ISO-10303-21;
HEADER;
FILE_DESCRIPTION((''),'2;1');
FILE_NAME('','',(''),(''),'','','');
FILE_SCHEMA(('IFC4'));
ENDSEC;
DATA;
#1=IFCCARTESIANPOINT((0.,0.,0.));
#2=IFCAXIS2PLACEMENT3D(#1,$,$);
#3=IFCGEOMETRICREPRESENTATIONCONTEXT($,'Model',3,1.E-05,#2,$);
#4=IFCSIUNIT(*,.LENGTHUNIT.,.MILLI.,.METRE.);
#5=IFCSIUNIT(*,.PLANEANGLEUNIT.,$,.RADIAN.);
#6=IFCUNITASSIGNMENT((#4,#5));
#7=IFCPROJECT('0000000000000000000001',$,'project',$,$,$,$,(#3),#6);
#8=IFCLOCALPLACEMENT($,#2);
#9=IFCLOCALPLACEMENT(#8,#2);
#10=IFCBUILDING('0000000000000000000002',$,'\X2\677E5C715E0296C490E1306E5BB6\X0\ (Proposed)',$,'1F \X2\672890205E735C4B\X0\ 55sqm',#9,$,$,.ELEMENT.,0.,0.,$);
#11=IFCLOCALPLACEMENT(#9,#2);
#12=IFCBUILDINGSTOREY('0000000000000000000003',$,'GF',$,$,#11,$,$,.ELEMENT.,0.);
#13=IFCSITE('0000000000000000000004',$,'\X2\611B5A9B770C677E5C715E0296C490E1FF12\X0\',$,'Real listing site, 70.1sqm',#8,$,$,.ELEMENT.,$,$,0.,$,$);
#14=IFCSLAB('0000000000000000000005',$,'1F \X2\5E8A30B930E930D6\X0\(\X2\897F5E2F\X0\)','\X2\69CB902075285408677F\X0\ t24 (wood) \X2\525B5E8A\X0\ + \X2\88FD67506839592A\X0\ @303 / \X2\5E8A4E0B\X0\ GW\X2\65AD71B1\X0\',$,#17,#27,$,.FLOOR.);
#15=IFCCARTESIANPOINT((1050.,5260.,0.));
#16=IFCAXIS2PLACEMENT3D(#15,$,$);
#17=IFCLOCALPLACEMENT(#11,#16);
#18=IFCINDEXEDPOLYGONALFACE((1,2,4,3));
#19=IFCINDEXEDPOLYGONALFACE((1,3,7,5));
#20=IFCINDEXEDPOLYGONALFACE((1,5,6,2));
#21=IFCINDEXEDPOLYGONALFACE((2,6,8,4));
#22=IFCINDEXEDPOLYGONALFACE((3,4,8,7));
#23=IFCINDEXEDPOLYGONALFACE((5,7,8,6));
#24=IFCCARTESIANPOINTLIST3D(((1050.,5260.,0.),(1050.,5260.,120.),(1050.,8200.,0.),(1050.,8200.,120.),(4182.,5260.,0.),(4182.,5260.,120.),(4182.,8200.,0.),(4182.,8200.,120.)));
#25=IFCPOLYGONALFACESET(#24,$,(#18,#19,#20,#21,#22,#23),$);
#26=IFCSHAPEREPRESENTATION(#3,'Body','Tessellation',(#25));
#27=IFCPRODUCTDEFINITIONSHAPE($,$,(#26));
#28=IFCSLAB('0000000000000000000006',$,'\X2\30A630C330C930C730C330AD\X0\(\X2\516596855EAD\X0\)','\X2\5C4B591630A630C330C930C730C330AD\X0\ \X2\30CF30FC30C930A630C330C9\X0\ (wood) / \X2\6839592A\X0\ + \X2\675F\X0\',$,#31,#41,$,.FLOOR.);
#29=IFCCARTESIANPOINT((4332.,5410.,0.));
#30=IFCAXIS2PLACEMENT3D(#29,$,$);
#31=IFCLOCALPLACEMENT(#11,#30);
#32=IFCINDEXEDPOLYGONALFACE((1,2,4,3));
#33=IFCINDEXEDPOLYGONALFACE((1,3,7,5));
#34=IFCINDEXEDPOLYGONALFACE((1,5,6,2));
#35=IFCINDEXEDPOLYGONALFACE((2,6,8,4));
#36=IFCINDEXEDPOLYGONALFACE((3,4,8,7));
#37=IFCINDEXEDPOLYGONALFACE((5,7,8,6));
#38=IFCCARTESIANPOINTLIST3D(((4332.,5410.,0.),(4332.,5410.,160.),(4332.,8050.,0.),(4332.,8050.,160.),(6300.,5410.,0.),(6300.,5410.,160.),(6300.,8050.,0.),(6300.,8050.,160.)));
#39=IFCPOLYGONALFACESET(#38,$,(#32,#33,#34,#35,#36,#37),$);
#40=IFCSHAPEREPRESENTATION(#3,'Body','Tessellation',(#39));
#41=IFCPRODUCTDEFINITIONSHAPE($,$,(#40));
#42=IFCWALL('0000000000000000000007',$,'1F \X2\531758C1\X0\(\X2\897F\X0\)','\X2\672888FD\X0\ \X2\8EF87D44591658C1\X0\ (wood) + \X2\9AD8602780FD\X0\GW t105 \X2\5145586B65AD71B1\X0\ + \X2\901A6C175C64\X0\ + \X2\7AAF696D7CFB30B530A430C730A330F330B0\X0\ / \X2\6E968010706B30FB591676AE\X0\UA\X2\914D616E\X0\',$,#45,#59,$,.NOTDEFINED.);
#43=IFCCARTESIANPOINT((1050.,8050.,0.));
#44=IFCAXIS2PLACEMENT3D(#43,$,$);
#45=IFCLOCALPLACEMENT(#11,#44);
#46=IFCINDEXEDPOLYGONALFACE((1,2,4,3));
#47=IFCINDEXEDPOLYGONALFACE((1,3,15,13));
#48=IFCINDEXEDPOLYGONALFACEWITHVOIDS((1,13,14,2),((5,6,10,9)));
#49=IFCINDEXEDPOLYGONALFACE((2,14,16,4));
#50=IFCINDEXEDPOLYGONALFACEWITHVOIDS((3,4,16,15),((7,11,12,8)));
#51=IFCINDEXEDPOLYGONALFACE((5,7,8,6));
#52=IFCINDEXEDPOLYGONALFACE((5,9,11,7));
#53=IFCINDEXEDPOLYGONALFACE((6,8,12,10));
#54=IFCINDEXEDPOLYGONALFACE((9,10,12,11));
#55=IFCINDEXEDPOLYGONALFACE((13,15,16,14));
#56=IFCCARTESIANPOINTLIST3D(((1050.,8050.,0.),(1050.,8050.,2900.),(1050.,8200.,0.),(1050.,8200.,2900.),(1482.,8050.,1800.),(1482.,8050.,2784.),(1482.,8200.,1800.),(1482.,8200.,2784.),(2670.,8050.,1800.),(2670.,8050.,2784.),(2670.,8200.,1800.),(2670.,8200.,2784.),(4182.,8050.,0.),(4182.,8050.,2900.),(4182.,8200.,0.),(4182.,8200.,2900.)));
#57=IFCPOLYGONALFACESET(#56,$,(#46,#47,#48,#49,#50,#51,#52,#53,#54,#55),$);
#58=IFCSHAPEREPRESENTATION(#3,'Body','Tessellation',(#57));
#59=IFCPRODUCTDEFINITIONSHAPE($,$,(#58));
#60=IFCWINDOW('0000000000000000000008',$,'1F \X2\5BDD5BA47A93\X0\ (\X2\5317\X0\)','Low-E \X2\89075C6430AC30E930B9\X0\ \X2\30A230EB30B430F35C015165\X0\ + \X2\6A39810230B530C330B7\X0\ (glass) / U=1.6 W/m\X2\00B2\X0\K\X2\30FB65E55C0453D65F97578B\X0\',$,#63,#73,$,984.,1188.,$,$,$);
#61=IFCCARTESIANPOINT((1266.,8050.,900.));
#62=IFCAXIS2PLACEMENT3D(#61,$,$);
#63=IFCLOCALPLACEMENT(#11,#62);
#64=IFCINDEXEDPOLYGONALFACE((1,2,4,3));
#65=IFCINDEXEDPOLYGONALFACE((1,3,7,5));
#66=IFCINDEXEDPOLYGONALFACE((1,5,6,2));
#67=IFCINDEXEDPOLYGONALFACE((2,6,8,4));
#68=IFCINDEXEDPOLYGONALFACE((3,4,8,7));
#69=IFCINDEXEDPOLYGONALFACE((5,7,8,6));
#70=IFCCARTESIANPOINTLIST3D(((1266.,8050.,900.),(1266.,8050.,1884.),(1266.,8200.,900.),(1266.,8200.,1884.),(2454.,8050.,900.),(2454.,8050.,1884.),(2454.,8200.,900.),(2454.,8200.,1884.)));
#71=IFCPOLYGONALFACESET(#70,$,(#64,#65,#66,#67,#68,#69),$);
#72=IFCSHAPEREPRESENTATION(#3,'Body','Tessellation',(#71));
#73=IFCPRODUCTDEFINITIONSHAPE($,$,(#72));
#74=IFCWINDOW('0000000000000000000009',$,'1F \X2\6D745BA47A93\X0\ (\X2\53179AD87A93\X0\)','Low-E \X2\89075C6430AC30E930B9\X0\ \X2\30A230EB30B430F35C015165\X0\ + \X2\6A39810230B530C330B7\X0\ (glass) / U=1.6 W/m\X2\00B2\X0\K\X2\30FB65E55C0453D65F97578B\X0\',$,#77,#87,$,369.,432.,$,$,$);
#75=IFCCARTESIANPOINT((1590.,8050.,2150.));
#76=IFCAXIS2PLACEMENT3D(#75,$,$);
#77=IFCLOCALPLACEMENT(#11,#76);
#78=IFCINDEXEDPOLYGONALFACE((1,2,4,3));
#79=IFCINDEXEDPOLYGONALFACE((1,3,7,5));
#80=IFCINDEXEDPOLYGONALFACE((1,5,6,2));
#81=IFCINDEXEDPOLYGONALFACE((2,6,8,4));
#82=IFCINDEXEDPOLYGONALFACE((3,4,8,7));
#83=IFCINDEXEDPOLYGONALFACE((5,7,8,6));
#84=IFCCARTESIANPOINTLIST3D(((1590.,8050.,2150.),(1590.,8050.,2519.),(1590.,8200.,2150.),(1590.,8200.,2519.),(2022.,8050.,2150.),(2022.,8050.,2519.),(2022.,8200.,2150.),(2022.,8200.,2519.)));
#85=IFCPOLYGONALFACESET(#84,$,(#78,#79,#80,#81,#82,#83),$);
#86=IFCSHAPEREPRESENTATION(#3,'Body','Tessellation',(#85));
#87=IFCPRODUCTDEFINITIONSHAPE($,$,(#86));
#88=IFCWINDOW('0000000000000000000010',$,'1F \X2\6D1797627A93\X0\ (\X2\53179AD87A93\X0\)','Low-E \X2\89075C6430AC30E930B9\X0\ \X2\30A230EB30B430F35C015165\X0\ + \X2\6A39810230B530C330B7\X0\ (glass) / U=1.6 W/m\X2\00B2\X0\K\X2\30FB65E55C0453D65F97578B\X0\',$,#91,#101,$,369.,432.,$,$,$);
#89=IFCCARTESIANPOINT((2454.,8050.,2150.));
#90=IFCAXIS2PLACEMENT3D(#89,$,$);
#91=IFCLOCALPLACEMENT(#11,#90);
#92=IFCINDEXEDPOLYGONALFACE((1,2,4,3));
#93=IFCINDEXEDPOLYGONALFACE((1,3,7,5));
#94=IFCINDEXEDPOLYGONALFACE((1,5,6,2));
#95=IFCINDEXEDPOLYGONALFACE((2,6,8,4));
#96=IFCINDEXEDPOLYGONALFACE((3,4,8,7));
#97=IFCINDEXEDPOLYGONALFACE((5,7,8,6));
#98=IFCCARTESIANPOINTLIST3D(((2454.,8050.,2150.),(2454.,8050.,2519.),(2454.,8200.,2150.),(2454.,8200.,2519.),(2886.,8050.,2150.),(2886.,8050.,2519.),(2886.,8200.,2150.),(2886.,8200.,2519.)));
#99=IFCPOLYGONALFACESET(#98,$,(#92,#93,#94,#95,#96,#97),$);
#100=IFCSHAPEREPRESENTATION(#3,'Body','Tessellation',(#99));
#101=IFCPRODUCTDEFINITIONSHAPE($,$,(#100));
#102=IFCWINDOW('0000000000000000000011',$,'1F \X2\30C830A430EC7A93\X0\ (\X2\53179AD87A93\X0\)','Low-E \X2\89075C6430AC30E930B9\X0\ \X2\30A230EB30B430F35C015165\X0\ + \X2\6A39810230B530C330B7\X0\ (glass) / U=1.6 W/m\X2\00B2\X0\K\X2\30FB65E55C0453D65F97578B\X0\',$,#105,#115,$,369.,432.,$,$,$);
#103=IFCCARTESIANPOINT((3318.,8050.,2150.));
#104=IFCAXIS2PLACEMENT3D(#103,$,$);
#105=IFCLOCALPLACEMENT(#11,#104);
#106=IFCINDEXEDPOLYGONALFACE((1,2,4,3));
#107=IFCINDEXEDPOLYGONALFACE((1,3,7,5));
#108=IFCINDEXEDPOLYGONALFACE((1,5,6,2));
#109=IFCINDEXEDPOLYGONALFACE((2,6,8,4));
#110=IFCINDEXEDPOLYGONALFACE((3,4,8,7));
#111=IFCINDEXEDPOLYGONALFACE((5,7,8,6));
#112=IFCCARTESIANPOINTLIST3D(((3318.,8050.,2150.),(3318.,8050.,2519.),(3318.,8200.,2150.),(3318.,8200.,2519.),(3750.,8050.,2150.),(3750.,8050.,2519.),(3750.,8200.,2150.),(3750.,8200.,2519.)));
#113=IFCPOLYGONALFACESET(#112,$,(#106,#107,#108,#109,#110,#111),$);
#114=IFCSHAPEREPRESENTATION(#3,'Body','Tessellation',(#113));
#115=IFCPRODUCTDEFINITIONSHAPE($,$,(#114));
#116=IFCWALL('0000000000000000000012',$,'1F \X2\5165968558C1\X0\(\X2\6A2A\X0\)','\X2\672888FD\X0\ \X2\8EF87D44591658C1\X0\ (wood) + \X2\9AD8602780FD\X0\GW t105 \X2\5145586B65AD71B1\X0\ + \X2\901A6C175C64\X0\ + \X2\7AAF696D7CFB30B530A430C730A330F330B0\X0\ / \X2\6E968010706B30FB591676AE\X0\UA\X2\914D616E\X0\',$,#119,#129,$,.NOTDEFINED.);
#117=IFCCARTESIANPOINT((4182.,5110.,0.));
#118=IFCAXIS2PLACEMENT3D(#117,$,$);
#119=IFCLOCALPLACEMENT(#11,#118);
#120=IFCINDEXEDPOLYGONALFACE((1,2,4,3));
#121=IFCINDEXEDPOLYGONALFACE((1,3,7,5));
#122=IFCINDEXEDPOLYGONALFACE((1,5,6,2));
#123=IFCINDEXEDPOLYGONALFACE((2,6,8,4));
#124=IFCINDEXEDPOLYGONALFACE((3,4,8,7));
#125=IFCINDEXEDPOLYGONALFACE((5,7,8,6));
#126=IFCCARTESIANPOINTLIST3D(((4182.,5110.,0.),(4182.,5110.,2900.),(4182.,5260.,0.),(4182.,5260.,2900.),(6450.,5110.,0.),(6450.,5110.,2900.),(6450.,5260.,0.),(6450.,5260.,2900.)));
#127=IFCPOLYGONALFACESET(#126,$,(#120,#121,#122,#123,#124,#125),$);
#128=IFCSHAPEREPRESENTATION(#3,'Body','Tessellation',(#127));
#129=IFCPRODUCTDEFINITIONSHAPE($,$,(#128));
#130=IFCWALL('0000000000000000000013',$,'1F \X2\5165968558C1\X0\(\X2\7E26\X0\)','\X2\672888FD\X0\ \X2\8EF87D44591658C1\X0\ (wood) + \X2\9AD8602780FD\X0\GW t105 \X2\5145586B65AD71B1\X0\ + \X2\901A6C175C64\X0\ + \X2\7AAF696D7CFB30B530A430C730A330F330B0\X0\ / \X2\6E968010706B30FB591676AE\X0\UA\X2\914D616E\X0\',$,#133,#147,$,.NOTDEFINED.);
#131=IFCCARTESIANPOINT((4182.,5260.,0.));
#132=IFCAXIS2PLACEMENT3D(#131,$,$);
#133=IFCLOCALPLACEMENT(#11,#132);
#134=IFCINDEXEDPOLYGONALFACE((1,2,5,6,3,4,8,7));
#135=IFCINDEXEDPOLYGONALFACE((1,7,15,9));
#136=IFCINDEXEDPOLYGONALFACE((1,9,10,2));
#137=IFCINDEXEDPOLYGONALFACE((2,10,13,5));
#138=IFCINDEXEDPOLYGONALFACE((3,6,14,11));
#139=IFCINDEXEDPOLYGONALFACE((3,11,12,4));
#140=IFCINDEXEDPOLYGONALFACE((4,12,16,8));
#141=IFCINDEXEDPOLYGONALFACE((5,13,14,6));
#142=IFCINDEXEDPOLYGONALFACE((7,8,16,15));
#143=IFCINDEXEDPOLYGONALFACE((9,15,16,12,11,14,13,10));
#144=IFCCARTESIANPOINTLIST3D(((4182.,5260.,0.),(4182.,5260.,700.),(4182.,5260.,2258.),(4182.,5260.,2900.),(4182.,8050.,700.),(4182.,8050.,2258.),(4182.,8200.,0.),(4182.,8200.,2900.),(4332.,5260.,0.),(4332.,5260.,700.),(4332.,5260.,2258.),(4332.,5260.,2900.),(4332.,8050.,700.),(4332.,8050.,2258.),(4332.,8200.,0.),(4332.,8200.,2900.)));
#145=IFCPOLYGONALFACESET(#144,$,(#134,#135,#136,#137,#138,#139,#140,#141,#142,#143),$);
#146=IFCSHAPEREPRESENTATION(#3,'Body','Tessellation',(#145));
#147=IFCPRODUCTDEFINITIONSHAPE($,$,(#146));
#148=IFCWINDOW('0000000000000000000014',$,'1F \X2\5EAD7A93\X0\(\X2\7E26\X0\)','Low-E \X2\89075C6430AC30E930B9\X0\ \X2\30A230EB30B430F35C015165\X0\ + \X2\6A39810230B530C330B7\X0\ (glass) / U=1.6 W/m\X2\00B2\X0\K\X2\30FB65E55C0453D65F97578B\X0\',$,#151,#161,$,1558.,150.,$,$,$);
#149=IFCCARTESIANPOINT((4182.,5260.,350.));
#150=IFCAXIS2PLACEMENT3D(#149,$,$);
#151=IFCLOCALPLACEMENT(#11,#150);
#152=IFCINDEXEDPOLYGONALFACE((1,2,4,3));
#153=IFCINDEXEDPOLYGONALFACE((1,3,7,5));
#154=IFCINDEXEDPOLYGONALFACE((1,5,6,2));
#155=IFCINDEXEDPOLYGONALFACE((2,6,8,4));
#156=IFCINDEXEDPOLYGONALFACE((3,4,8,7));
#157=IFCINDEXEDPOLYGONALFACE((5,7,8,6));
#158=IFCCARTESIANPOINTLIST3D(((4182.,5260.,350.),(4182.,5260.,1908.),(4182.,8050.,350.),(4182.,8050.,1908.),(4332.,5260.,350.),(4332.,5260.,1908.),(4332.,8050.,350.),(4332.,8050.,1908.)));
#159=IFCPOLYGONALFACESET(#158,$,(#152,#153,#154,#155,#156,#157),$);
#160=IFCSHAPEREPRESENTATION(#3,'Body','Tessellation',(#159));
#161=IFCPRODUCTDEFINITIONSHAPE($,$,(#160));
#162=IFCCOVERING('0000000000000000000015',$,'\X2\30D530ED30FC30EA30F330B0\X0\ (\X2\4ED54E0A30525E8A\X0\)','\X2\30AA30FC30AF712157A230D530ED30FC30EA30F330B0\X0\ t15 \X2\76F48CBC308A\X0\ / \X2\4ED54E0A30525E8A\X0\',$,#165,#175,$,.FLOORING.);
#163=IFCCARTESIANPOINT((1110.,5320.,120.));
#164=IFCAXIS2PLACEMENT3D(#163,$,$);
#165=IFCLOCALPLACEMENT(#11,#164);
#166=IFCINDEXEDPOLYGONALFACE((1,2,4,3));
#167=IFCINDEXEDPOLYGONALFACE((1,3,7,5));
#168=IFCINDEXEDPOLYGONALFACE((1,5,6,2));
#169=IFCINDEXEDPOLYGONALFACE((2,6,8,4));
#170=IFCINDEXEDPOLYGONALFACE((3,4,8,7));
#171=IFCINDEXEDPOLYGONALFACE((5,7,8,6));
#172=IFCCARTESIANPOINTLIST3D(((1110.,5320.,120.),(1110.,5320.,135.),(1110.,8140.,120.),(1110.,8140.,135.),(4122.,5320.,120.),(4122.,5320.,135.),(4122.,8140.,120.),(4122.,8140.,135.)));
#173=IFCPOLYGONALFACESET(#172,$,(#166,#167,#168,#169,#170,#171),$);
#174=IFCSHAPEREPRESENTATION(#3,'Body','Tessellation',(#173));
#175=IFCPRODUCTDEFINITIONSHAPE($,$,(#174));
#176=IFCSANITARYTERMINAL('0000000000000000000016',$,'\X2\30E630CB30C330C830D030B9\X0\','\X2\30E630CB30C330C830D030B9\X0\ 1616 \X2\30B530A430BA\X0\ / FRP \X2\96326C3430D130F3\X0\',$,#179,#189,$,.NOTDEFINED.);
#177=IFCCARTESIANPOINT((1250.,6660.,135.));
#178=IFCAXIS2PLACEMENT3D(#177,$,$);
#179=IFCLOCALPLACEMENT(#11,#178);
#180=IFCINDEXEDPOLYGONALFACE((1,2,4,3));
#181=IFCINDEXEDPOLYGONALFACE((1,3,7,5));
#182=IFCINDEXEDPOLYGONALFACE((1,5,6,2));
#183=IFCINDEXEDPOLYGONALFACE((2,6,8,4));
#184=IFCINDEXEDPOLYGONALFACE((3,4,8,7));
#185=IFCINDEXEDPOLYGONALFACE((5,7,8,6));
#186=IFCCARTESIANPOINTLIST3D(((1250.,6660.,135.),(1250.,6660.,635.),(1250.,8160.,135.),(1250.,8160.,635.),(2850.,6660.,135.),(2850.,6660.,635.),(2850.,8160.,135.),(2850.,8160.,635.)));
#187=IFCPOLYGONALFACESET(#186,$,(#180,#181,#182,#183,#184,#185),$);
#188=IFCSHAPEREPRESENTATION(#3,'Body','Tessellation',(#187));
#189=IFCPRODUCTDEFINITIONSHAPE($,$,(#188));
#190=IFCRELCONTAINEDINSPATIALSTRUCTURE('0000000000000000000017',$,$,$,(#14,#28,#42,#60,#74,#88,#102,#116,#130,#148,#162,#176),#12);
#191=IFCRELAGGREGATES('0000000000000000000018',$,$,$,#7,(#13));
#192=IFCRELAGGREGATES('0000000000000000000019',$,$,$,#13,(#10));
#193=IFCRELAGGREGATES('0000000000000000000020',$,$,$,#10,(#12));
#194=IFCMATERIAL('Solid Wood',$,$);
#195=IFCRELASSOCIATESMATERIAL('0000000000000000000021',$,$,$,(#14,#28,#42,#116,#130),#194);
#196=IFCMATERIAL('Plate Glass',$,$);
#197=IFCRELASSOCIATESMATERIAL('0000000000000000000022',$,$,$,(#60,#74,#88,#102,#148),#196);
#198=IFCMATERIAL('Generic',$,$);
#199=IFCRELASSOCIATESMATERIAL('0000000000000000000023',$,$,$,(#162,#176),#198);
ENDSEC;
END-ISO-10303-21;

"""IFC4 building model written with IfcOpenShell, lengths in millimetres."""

from ifc_helpers import new_model, si_unit, frame, frame_2d, origin, place, context, project, spatial, rectangle, extrude, material, element, fill, save


model = new_model("IFC4")

# Units and contexts
model_context = context("Model", 3, precision=1e-05, world=origin())
ifc_project = project(units=[si_unit("LENGTHUNIT", "METRE", prefix="MILLI"), si_unit("PLANEANGLEUNIT", "RADIAN")], contexts=[model_context])

# Site, building, storey
site_placement = place(None, origin())
site = spatial("IfcSite", under=ifc_project, at=site_placement, Name="愛媛県松山市雄郡２", ObjectType="Real listing site, 70.1sqm", CompositionType="ELEMENT", RefElevation=0.0)
building_placement = place(site_placement, origin())
building = spatial("IfcBuilding", under=site, at=building_placement, Name="松山市雄郡の家 (Proposed)", ObjectType="1F 木造平屋 55sqm", CompositionType="ELEMENT", ElevationOfRefHeight=0.0, ElevationOfTerrain=0.0)
storey_placement = place(building_placement, origin())
storey = spatial("IfcBuildingStorey", under=building, at=storey_placement, Name="GF", CompositionType="ELEMENT", Elevation=0.0)

# Slabs
ifc_material_1 = material(Name="Solid Wood")
slab_1_placement = place(storey_placement, frame((1050.0, 5260.0, 0.0)))
element("IfcSlab", 1, at=slab_1_placement, inside=storey, material=ifc_material_1, Name="1F 床スラブ(西帯)", Description="構造用合板 t24 (wood) 剛床 + 製材根太 @303 / 床下 GW断熱", PredefinedType="FLOOR", context=model_context, shape_type="SweptSolid", body=[
    extrude(rectangle(XDim=3132.0, YDim=2940.0, at=frame_2d((1566.0, 1470.0))), frame((1050.0, 5260.0, 0.0)), (0.0, 0.0, 1.0), 120.0),
])
slab_2_placement = place(storey_placement, frame((4332.0, 5410.0, 0.0)))
element("IfcSlab", 2, at=slab_2_placement, inside=storey, material=ifc_material_1, Name="ウッドデッキ(入隅庭)", Description="屋外ウッドデッキ ハードウッド (wood) / 根太 + 束", PredefinedType="FLOOR", context=model_context, shape_type="SweptSolid", body=[
    extrude(rectangle(XDim=1968.0, YDim=2640.0, at=frame_2d((984.0, 1320.0))), frame((4332.0, 5410.0, 0.0)), (0.0, 0.0, 1.0), 160.0),
])

# Wall, openings, windows
wall_1_placement = place(storey_placement, frame((1050.0, 8050.0, 0.0)))
wall_1 = element("IfcWall", 3, at=wall_1_placement, inside=storey, material=ifc_material_1, Name="1F 北壁(西)", Description="木製 軸組外壁 (wood) + 高性能GW t105 充填断熱 + 通気層 + 窯業系サイディング / 準耐火・外皮UA配慮", PredefinedType="NOTDEFINED", context=model_context, shape_type="SweptSolid", body=[
    extrude(rectangle(XDim=3132.0, YDim=150.0, at=frame_2d((1566.0, 75.0))), frame((1050.0, 8050.0, 0.0)), (0.0, 0.0, 1.0), 2900.0),
])
opening_1_placement = place(storey_placement, frame((1266.0, 8050.0, 900.0)))
opening_1 = element("IfcOpeningElement", 4, at=opening_1_placement, cuts=wall_1, PredefinedType="NOTDEFINED", context=model_context, shape_type="SweptSolid", body=[
    extrude(rectangle(XDim=1188.0, YDim=150.0, at=frame_2d((594.0, 75.0))), frame((1266.0, 8050.0, 900.0)), (0.0, 0.0, 1.0), 984.0),
])
opening_2_placement = place(storey_placement, frame((1590.0, 8050.0, 2150.0)))
opening_2 = element("IfcOpeningElement", 5, at=opening_2_placement, cuts=wall_1, PredefinedType="NOTDEFINED", context=model_context, shape_type="SweptSolid", body=[
    extrude(rectangle(XDim=432.0, YDim=150.0, at=frame_2d((216.0, 75.0))), frame((1590.0, 8050.0, 2150.0)), (0.0, 0.0, 1.0), 369.0),
])
opening_3_placement = place(storey_placement, frame((2454.0, 8050.0, 2150.0)))
opening_3 = element("IfcOpeningElement", 6, at=opening_3_placement, cuts=wall_1, PredefinedType="NOTDEFINED", context=model_context, shape_type="SweptSolid", body=[
    extrude(rectangle(XDim=432.0, YDim=150.0, at=frame_2d((216.0, 75.0))), frame((2454.0, 8050.0, 2150.0)), (0.0, 0.0, 1.0), 369.0),
])
opening_4_placement = place(storey_placement, frame((3318.0, 8050.0, 2150.0)))
opening_4 = element("IfcOpeningElement", 7, at=opening_4_placement, cuts=wall_1, PredefinedType="NOTDEFINED", context=model_context, shape_type="SweptSolid", body=[
    extrude(rectangle(XDim=432.0, YDim=150.0, at=frame_2d((216.0, 75.0))), frame((3318.0, 8050.0, 2150.0)), (0.0, 0.0, 1.0), 369.0),
])
ifc_material_2 = material(Name="Plate Glass")
window_1_placement = place(storey_placement, frame((1266.0, 8050.0, 900.0)))
window_1 = element("IfcWindow", 8, at=window_1_placement, inside=storey, material=ifc_material_2, Name="1F 寝室窓 (北)", Description="Low-E 複層ガラス アルゴン封入 + 樹脂サッシ (glass) / U=1.6 W/m²K・日射取得型", OverallHeight=984.0, OverallWidth=1188.0, context=model_context, shape_type="SweptSolid", body=[
    extrude(rectangle(XDim=1188.0, YDim=150.0, at=frame_2d((594.0, 75.0))), frame((1266.0, 8050.0, 900.0)), (0.0, 0.0, 1.0), 984.0),
])
fill(opening_1, window_1)
window_2_placement = place(storey_placement, frame((1590.0, 8050.0, 2150.0)))
window_2 = element("IfcWindow", 9, at=window_2_placement, inside=storey, material=ifc_material_2, Name="1F 浴室窓 (北高窓)", Description="Low-E 複層ガラス アルゴン封入 + 樹脂サッシ (glass) / U=1.6 W/m²K・日射取得型", OverallHeight=369.0, OverallWidth=432.0, context=model_context, shape_type="SweptSolid", body=[
    extrude(rectangle(XDim=432.0, YDim=150.0, at=frame_2d((216.0, 75.0))), frame((1590.0, 8050.0, 2150.0)), (0.0, 0.0, 1.0), 369.0),
])
fill(opening_2, window_2)
window_3_placement = place(storey_placement, frame((2454.0, 8050.0, 2150.0)))
window_3 = element("IfcWindow", 10, at=window_3_placement, inside=storey, material=ifc_material_2, Name="1F 洗面窓 (北高窓)", Description="Low-E 複層ガラス アルゴン封入 + 樹脂サッシ (glass) / U=1.6 W/m²K・日射取得型", OverallHeight=369.0, OverallWidth=432.0, context=model_context, shape_type="SweptSolid", body=[
    extrude(rectangle(XDim=432.0, YDim=150.0, at=frame_2d((216.0, 75.0))), frame((2454.0, 8050.0, 2150.0)), (0.0, 0.0, 1.0), 369.0),
])
fill(opening_3, window_3)
window_4_placement = place(storey_placement, frame((3318.0, 8050.0, 2150.0)))
window_4 = element("IfcWindow", 11, at=window_4_placement, inside=storey, material=ifc_material_2, Name="1F トイレ窓 (北高窓)", Description="Low-E 複層ガラス アルゴン封入 + 樹脂サッシ (glass) / U=1.6 W/m²K・日射取得型", OverallHeight=369.0, OverallWidth=432.0, context=model_context, shape_type="SweptSolid", body=[
    extrude(rectangle(XDim=432.0, YDim=150.0, at=frame_2d((216.0, 75.0))), frame((3318.0, 8050.0, 2150.0)), (0.0, 0.0, 1.0), 369.0),
])
fill(opening_4, window_4)

# Wall
wall_2_placement = place(storey_placement, frame((4182.0, 5110.0, 0.0)))
element("IfcWall", 12, at=wall_2_placement, inside=storey, material=ifc_material_1, Name="1F 入隅壁(横)", Description="木製 軸組外壁 (wood) + 高性能GW t105 充填断熱 + 通気層 + 窯業系サイディング / 準耐火・外皮UA配慮", PredefinedType="NOTDEFINED", context=model_context, shape_type="SweptSolid", body=[
    extrude(rectangle(XDim=2268.0, YDim=150.0, at=frame_2d((1134.0, 75.0))), frame((4182.0, 5110.0, 0.0)), (0.0, 0.0, 1.0), 2900.0),
])

# Wall, opening, window
wall_3_placement = place(storey_placement, frame((4182.0, 5260.0, 0.0)))
wall_3 = element("IfcWall", 13, at=wall_3_placement, inside=storey, material=ifc_material_1, Name="1F 入隅壁(縦)", Description="木製 軸組外壁 (wood) + 高性能GW t105 充填断熱 + 通気層 + 窯業系サイディング / 準耐火・外皮UA配慮", PredefinedType="NOTDEFINED", context=model_context, shape_type="SweptSolid", body=[
    extrude(rectangle(XDim=150.0, YDim=2940.0, at=frame_2d((75.0, 1470.0))), frame((4182.0, 5260.0, 0.0)), (0.0, 0.0, 1.0), 2900.0),
])
opening_5_placement = place(storey_placement, frame((4182.0, 5260.0, 350.0)))
opening_5 = element("IfcOpeningElement", 14, at=opening_5_placement, cuts=wall_3, PredefinedType="NOTDEFINED", context=model_context, shape_type="SweptSolid", body=[
    extrude(rectangle(XDim=150.0, YDim=2790.0, at=frame_2d((75.0, 1395.0))), frame((4182.0, 5260.0, 350.0)), (0.0, 0.0, 1.0), 1558.0),
])
window_5_placement = place(storey_placement, frame((4182.0, 5260.0, 350.0)))
window_5 = element("IfcWindow", 15, at=window_5_placement, inside=storey, material=ifc_material_2, Name="1F 庭窓(縦)", Description="Low-E 複層ガラス アルゴン封入 + 樹脂サッシ (glass) / U=1.6 W/m²K・日射取得型", OverallHeight=1558.0, OverallWidth=150.0, context=model_context, shape_type="SweptSolid", body=[
    extrude(rectangle(XDim=150.0, YDim=2790.0, at=frame_2d((75.0, 1395.0))), frame((4182.0, 5260.0, 350.0)), (0.0, 0.0, 1.0), 1558.0),
])
fill(opening_5, window_5)

# Covering
ifc_material_3 = material(Name="Generic")
covering_placement = place(storey_placement, frame((1110.0, 5320.0, 120.0)))
element("IfcCovering", 16, at=covering_placement, inside=storey, material=ifc_material_3, Name="フローリング (仕上げ床)", Description="オーク無垢フローリング t15 直貼り / 仕上げ床", PredefinedType="FLOORING", context=model_context, shape_type="SweptSolid", body=[
    extrude(rectangle(XDim=3012.0, YDim=2820.0, at=frame_2d((1506.0, 1410.0))), frame((1110.0, 5320.0, 120.0)), (0.0, 0.0, 1.0), 15.0),
])

# Sanitary terminal
sanitary_terminal_1_placement = place(storey_placement, frame((1250.0, 6660.0, 135.0)))
element("IfcSanitaryTerminal", 17, at=sanitary_terminal_1_placement, inside=storey, material=ifc_material_3, Name="ユニットバス", Description="ユニットバス 1616 サイズ / FRP 防水パン", PredefinedType="NOTDEFINED", context=model_context, shape_type="SweptSolid", body=[
    extrude(rectangle(XDim=1600.0, YDim=1500.0, at=frame_2d((800.0, 750.0))), frame((1250.0, 6660.0, 135.0)), (0.0, 0.0, 1.0), 500.0),
])

save(model, "model.ifc")
